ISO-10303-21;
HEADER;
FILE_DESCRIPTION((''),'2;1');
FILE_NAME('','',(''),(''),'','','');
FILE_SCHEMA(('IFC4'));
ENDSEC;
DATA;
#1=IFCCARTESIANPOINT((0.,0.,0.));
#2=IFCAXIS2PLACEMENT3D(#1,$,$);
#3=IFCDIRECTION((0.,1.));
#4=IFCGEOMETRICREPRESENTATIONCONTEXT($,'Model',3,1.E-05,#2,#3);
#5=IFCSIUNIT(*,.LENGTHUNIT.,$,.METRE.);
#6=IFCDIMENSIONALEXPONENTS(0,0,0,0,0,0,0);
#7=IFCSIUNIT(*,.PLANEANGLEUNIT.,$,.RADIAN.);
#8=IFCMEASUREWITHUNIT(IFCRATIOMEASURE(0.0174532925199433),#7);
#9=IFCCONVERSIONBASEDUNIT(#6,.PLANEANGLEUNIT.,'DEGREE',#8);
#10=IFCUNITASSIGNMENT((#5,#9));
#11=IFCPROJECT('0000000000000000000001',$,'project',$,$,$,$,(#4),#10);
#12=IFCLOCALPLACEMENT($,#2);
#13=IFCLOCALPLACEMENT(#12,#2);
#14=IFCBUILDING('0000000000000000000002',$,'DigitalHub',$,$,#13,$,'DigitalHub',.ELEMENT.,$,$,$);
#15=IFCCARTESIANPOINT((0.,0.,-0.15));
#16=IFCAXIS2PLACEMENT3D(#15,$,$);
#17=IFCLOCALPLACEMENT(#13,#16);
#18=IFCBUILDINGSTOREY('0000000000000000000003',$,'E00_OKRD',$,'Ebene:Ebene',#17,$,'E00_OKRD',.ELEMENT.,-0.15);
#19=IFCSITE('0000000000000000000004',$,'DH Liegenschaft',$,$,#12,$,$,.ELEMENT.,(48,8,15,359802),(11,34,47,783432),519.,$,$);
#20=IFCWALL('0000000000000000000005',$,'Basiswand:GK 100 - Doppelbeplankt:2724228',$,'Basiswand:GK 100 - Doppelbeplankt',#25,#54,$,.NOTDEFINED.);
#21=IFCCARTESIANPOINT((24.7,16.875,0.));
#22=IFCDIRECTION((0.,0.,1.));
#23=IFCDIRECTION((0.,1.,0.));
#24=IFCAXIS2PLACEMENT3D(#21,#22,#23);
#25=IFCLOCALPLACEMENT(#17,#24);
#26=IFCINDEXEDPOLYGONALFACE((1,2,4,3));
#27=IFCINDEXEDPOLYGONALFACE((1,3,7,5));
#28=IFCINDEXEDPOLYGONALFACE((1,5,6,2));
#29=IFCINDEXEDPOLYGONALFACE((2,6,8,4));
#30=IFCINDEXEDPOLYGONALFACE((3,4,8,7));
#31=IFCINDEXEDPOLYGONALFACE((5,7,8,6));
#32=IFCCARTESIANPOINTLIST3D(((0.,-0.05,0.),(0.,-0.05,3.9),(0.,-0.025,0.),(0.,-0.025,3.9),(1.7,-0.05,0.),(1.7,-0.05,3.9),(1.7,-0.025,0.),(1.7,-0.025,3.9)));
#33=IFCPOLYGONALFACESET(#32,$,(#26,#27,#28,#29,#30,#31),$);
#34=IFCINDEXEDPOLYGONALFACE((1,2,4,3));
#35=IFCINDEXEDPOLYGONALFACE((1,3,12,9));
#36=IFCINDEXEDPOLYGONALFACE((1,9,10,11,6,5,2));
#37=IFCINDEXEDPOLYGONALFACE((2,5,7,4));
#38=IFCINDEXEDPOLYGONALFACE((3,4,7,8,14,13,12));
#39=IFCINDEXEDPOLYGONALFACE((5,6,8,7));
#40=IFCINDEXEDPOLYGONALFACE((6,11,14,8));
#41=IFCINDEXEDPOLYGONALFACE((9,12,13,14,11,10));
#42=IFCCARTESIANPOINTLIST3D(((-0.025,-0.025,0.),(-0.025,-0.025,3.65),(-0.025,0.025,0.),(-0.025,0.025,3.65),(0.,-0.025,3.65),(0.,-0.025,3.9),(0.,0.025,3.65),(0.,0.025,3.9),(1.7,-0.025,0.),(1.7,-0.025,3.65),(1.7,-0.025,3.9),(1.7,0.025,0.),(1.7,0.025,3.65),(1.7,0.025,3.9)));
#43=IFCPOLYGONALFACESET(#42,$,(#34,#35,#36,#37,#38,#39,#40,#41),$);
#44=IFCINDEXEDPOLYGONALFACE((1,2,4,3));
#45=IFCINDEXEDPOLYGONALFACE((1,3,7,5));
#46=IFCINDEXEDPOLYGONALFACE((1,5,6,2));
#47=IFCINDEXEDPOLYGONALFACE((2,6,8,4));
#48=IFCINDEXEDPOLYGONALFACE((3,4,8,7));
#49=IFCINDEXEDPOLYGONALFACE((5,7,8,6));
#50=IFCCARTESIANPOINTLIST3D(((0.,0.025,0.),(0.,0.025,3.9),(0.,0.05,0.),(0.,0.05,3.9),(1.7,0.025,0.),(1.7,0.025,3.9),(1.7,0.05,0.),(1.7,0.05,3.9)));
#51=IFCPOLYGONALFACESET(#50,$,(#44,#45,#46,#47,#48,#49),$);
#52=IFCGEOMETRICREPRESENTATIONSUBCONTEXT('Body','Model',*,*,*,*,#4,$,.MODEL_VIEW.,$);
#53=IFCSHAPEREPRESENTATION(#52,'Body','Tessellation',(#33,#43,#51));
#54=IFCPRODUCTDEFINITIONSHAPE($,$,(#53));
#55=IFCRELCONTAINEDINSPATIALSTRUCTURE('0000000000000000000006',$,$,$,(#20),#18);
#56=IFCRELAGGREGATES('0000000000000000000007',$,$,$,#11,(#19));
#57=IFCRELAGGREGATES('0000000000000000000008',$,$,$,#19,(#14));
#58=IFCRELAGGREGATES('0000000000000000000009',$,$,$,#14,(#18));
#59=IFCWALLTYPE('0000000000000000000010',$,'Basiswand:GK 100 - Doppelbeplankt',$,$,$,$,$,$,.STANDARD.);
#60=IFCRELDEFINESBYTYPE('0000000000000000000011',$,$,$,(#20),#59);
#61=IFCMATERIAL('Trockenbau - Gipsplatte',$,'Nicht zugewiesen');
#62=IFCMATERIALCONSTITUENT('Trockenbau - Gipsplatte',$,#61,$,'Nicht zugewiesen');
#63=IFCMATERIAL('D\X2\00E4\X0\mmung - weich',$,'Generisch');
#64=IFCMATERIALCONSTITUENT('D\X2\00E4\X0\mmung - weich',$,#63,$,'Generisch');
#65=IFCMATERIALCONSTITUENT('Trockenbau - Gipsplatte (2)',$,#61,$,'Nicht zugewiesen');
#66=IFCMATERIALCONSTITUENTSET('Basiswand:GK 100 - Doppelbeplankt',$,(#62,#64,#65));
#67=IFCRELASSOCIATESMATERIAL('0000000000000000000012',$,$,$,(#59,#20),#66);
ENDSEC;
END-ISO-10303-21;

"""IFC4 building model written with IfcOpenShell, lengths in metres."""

from ifc_helpers import new_model, entity, si_unit, converted_unit, direction, frame, origin, place, context, subcontext, project, spatial, indexed_curve, outline, extrude, material, constituent, constituent_set, type_object, element, save


model = new_model("IFC4")

# Units and contexts
model_context = context("Model", 3, precision=1e-05, world=origin(), true_north=direction((0.0, 1.0)))
body_context = subcontext(model_context, "Body", "Model", "MODEL_VIEW")
ifc_project = project(units=[si_unit("LENGTHUNIT", "METRE"), converted_unit("PLANEANGLEUNIT", "DEGREE", entity("IfcRatioMeasure", 0.0174532925199433), si_unit("PLANEANGLEUNIT", "RADIAN"), dimensions=[0, 0, 0, 0, 0, 0, 0])], contexts=[model_context])

# Site, building, storey
site_placement = place(None, frame((0.0, 0.0, 0.0)))
site = spatial("IfcSite", under=ifc_project, at=site_placement, Name="DH Liegenschaft", CompositionType="ELEMENT", RefLatitude=(48, 8, 15, 359802), RefLongitude=(11, 34, 47, 783432), RefElevation=519.0)
building_placement = place(site_placement, origin())
building = spatial("IfcBuilding", under=site, at=building_placement, Name="DigitalHub", LongName="DigitalHub", CompositionType="ELEMENT")
storey_placement = place(building_placement, frame((0.0, 0.0, -0.15)))
storey = spatial("IfcBuildingStorey", under=building, at=storey_placement, Name="E00_OKRD", ObjectType="Ebene:Ebene", LongName="E00_OKRD", CompositionType="ELEMENT", Elevation=-0.15)

# Wall
ifc_material_1 = material(Name="Trockenbau - Gipsplatte", Category="Nicht zugewiesen")
ifc_material_2 = material(Name="Dämmung - weich", Category="Generisch")
ifc_constituent_1 = constituent(ifc_material_1, Name="Trockenbau - Gipsplatte", Category="Nicht zugewiesen")
ifc_constituent_2 = constituent(ifc_material_2, Name="Dämmung - weich", Category="Generisch")
ifc_constituent_3 = constituent(ifc_material_1, Name="Trockenbau - Gipsplatte (2)", Category="Nicht zugewiesen")
ifc_constituent_set_1 = constituent_set(constituents=[ifc_constituent_1, ifc_constituent_2, ifc_constituent_3], Name="Basiswand:GK 100 - Doppelbeplankt")
wall_type_1 = type_object("IfcWallType", Name="Basiswand:GK 100 - Doppelbeplankt", PredefinedType="STANDARD", material=ifc_constituent_set_1)
wall_1_placement = place(storey_placement, frame((24.7, 16.875, 0.0), z_axis=(0.0, 0.0, 1.0), x_axis=(0.0, 1.0, 0.0)))
element("IfcWall", 1, at=wall_1_placement, inside=storey, type_object=wall_type_1, material=ifc_constituent_set_1, Name="Basiswand:GK 100 - Doppelbeplankt:2724228", ObjectType="Basiswand:GK 100 - Doppelbeplankt", PredefinedType="NOTDEFINED", context=body_context, shape_type="SweptSolid", body=[
    extrude(outline(indexed_curve([(-0.0125, -0.85), (0.0125, -0.85), (0.0125, 0.85), (-0.0125, 0.85), (-0.0125, -0.85)], self_intersect=False)), frame((0.85, -0.0375, 0.0), z_axis=(0.0, 0.0, 1.0), x_axis=(0.0, 1.0, 0.0)), (0.0, 0.0, 1.0), 3.9),
    extrude(outline(indexed_curve([(-2.6786, -0.9786), (0.9714, -0.9786), (1.2214, -0.9786), (1.2214, 0.7214), (0.9714, 0.7214), (0.9714, 0.7464), (-2.6786, 0.7464), (-2.6786, -0.9786)], self_intersect=False)), frame((0.7214, 0.025, 2.6786), z_axis=(0.0, -1.0, 0.0), x_axis=(0.0, 0.0, 1.0)), (0.0, 0.0, 1.0), 0.05),
    extrude(outline(indexed_curve([(-0.0125, -0.85), (0.0125, -0.85), (0.0125, 0.85), (-0.0125, 0.85), (-0.0125, -0.85)], self_intersect=False)), frame((0.85, 0.0375, 0.0), z_axis=(0.0, 0.0, 1.0), x_axis=(0.0, 1.0, 0.0)), (0.0, 0.0, 1.0), 3.9),
])

save(model, "model.ifc")
